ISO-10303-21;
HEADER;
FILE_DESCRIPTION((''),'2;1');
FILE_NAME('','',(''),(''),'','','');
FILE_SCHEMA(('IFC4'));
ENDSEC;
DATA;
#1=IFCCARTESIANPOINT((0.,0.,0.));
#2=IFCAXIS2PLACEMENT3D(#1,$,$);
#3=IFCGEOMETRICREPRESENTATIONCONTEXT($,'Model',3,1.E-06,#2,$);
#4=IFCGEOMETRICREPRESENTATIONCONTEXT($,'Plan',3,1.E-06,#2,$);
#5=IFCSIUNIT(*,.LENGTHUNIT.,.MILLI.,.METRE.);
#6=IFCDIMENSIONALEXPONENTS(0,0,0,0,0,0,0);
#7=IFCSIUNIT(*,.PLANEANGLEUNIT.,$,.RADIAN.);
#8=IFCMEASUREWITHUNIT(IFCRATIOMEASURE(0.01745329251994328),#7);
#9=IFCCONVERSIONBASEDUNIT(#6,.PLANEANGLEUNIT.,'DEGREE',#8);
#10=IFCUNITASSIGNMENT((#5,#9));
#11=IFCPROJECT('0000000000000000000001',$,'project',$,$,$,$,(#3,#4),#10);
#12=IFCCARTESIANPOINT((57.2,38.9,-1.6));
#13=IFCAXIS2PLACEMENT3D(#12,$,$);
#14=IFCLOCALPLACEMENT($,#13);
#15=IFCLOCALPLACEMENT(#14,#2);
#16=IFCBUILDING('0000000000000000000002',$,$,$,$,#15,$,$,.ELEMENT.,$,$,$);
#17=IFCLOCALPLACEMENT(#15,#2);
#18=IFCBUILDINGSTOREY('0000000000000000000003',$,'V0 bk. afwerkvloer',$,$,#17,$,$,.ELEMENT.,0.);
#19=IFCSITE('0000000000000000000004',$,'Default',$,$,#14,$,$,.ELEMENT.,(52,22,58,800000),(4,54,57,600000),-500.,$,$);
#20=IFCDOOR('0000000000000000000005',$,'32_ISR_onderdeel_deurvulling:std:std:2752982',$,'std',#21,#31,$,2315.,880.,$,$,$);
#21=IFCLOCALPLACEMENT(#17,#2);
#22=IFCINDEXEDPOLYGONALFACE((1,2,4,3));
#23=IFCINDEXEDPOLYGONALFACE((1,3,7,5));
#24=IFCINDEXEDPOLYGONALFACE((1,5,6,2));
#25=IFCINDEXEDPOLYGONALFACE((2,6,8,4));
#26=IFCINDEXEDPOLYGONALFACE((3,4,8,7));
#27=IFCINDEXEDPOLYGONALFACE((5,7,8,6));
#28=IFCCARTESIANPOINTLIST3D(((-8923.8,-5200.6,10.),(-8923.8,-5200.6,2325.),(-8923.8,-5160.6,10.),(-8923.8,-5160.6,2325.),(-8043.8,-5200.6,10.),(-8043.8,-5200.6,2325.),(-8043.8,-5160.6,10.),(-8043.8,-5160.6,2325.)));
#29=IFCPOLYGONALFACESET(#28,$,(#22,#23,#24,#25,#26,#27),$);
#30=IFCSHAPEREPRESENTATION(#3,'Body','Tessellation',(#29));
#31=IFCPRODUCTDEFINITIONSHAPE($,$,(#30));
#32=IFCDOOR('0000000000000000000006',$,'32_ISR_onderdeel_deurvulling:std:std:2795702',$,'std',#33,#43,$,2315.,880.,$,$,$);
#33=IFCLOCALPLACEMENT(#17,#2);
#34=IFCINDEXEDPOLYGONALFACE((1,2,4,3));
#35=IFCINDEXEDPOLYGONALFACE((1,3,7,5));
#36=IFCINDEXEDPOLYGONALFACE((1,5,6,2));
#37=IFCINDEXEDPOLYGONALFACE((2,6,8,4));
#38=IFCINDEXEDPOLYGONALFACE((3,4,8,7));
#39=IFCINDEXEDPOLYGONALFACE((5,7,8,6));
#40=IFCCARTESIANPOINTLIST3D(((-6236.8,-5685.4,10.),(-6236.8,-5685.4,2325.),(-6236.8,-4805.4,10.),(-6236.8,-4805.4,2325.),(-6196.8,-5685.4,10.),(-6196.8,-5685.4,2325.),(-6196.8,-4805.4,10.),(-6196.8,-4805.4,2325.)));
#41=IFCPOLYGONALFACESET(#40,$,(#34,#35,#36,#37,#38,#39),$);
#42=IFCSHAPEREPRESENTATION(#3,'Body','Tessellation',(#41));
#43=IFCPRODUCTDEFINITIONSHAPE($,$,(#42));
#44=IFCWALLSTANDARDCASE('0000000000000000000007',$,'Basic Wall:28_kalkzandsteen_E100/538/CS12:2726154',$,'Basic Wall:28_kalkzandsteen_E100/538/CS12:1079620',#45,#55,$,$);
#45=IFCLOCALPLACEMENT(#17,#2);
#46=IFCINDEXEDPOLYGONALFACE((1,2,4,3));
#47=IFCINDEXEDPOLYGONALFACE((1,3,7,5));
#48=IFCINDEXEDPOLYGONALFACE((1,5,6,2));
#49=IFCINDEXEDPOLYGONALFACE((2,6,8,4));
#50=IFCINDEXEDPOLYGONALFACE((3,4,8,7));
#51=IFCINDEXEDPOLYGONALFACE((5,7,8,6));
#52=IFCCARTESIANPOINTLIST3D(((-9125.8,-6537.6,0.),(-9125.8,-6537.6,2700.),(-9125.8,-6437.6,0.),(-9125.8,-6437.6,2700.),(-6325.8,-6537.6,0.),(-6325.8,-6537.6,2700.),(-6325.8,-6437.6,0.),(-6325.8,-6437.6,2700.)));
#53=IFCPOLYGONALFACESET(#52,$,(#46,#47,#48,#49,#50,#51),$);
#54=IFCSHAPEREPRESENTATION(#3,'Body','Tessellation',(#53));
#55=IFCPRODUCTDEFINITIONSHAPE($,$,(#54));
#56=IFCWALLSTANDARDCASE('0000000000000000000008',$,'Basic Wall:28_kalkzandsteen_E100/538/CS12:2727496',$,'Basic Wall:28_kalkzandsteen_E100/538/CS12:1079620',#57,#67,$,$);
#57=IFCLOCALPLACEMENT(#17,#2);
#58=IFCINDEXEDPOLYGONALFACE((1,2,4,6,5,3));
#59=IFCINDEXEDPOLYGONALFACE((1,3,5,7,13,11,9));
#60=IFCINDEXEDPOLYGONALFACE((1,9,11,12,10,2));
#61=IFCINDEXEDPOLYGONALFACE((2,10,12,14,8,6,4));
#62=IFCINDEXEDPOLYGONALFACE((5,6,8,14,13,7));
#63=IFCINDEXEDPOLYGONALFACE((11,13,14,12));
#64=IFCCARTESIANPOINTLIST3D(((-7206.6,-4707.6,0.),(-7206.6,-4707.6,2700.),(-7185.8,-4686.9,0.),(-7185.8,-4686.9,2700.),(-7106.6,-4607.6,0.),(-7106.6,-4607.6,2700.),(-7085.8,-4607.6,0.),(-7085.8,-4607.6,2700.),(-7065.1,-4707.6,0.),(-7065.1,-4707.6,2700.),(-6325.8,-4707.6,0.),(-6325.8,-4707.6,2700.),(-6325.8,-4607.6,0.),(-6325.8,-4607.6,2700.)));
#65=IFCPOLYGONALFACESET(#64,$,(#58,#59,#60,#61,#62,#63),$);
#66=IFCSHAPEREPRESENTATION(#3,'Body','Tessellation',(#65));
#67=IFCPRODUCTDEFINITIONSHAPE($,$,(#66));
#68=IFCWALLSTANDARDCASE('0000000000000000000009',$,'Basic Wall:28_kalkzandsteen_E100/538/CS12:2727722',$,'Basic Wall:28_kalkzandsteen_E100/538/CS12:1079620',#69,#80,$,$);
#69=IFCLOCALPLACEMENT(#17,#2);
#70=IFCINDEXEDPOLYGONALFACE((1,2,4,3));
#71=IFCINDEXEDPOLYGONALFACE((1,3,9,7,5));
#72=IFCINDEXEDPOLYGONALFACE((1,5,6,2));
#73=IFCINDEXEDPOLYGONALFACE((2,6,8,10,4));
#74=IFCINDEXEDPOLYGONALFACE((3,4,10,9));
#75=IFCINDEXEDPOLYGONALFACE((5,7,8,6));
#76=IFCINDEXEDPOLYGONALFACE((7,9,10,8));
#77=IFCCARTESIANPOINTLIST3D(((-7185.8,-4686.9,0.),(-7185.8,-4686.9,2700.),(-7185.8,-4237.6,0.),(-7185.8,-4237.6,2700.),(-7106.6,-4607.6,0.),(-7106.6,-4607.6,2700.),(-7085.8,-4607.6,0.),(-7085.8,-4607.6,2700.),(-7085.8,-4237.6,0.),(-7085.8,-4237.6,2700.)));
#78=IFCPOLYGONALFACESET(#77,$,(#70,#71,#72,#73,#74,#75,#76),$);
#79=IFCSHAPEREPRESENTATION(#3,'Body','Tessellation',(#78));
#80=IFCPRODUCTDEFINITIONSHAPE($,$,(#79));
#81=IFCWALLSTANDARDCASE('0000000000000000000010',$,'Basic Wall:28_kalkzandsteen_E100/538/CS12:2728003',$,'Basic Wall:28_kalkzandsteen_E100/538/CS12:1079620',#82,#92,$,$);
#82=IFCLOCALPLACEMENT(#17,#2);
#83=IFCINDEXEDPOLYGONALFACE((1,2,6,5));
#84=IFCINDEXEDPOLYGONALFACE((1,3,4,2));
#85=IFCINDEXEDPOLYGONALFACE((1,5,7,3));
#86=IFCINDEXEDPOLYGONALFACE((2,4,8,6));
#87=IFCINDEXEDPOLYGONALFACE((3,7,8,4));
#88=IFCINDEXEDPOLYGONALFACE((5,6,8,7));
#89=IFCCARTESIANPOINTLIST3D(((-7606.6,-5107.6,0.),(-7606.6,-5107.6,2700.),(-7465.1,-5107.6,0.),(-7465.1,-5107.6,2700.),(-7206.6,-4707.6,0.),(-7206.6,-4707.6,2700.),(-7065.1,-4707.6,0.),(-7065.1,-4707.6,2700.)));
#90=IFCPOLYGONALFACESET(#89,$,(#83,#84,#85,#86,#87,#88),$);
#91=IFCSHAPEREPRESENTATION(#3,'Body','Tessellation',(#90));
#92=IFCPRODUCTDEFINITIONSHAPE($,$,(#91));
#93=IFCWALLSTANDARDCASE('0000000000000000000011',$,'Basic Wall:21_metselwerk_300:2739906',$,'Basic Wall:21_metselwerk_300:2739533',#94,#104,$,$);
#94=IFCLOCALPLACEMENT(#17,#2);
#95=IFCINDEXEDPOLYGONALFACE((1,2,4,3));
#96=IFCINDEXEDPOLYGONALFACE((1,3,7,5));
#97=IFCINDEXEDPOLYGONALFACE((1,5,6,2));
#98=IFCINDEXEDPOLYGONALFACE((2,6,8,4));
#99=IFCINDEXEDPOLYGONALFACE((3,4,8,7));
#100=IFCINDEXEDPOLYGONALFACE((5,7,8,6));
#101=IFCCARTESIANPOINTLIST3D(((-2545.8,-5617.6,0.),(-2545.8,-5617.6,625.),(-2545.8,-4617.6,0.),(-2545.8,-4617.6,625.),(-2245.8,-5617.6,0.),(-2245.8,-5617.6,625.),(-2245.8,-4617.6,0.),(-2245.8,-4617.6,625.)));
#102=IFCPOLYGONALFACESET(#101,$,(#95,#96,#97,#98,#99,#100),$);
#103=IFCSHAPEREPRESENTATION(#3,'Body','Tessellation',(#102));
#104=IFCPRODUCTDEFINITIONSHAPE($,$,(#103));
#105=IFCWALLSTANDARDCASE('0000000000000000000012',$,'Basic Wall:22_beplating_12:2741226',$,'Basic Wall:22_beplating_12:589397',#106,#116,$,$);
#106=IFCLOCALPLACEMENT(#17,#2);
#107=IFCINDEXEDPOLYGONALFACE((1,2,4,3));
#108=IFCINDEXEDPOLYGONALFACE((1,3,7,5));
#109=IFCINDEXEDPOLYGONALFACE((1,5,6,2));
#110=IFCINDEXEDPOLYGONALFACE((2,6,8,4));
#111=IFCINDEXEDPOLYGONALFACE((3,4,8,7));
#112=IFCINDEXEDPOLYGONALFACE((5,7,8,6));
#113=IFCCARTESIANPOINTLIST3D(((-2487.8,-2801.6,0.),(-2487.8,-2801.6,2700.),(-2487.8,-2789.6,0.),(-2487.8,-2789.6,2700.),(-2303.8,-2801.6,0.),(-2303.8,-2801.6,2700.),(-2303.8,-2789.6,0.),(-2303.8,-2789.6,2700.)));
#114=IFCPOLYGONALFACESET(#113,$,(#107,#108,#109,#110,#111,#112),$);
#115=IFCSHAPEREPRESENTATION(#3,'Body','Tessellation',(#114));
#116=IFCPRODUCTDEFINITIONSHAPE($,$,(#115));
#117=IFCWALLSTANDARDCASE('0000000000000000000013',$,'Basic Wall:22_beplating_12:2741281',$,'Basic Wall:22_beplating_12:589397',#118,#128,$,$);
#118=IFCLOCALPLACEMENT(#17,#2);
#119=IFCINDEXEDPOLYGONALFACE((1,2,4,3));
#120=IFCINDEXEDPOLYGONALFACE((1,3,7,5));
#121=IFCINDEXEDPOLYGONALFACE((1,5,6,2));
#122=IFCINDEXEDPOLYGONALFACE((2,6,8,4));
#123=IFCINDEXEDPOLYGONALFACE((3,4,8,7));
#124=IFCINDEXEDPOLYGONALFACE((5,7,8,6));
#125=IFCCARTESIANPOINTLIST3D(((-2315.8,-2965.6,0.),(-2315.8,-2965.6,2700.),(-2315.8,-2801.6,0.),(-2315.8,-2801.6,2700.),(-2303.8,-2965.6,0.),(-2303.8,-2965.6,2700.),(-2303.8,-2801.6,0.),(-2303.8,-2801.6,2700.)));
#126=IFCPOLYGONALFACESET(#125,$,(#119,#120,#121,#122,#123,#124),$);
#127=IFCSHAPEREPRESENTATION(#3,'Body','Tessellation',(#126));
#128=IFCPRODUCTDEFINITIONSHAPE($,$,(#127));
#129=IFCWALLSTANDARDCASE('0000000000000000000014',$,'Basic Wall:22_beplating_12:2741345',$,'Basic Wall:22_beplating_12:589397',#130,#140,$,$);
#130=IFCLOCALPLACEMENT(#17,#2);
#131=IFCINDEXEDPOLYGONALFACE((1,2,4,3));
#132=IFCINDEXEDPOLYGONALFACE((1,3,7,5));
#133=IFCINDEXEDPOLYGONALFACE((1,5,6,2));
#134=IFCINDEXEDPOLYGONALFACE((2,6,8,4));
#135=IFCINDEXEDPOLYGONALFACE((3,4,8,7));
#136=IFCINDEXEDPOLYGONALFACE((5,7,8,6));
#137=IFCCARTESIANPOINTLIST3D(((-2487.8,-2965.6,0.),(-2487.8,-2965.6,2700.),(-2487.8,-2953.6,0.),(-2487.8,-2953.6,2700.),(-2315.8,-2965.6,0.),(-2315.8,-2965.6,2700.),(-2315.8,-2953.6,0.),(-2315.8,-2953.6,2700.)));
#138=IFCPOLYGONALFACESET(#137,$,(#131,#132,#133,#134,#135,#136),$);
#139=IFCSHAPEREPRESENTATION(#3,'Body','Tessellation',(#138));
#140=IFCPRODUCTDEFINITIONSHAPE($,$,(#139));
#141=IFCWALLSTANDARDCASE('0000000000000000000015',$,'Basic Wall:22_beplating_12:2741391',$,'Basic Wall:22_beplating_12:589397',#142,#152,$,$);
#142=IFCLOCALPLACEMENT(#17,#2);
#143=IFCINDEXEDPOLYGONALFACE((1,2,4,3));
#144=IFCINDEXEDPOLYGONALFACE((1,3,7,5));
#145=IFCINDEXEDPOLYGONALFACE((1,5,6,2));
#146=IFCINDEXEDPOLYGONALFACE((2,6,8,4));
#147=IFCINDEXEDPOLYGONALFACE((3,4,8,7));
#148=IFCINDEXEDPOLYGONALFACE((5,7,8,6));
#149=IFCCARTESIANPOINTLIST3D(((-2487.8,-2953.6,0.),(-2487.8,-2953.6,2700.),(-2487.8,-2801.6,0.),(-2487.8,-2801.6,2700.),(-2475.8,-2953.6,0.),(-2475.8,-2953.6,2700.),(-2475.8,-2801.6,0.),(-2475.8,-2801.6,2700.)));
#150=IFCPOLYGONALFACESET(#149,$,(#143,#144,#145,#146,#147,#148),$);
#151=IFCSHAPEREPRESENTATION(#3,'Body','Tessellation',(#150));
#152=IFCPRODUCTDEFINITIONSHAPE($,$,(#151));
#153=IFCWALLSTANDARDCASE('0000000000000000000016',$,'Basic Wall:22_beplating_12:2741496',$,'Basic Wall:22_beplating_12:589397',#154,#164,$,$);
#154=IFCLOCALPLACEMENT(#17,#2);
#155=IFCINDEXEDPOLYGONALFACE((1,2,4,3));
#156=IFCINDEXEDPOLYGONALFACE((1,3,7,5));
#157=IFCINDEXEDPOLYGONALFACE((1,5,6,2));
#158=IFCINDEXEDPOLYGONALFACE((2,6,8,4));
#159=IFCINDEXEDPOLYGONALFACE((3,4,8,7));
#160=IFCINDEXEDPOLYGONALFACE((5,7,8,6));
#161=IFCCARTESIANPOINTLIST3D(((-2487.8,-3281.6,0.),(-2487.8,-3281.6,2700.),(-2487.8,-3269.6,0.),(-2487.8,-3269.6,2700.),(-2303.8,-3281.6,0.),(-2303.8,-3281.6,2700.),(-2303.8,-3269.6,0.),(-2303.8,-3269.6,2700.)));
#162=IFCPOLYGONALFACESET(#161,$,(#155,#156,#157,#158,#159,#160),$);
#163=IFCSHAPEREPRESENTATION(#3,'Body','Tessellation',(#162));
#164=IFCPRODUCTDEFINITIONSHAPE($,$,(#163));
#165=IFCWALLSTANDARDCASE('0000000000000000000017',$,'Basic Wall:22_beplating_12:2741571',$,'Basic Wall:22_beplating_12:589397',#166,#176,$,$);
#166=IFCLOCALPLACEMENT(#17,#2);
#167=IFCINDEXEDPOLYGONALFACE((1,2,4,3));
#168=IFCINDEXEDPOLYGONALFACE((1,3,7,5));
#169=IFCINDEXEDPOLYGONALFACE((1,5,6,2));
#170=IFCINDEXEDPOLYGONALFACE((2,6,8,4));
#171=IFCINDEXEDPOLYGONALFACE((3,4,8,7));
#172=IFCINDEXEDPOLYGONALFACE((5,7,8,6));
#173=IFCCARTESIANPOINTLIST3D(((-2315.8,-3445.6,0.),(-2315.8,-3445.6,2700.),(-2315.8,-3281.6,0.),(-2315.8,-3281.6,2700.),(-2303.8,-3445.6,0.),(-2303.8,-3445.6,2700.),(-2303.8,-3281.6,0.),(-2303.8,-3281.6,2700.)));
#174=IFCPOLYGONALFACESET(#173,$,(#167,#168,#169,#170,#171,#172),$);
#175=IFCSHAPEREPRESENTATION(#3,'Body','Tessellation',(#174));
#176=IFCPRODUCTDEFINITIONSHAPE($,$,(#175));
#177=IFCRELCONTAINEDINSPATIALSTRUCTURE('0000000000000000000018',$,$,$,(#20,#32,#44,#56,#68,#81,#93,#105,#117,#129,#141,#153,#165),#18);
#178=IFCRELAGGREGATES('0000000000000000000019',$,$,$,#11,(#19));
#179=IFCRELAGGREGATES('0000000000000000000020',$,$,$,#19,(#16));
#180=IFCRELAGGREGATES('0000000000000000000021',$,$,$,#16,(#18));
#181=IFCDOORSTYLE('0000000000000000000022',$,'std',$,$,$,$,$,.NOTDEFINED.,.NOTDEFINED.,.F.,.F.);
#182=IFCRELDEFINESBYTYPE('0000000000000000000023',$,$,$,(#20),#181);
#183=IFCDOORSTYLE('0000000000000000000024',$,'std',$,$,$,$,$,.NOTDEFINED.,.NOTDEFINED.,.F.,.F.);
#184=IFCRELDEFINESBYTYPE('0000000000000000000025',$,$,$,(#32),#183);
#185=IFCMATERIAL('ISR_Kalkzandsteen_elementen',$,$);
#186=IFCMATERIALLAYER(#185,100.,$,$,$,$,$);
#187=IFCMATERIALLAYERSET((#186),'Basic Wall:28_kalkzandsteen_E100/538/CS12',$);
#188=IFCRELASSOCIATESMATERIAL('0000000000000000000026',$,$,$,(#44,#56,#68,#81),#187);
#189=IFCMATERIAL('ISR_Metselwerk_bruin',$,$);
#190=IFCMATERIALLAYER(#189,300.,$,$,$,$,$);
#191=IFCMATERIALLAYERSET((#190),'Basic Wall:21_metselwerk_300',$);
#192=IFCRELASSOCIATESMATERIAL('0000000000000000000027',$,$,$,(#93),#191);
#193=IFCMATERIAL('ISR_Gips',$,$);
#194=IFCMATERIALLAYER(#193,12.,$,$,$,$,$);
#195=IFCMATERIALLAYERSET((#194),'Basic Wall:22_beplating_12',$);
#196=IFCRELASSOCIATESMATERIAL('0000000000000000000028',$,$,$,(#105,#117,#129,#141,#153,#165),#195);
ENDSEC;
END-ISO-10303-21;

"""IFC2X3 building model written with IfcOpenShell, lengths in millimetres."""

from ifc_helpers import new_model, entity, si_unit, converted_unit, frame, frame_2d, origin, origin_2d_with_axis, place, context, project, spatial, polyline, rectangle, outline, extrude, source, transform, mapped, material, layer, layer_set, layer_usage, type_object, type_shapes, element, save


model = new_model("IFC2X3")

# Units and contexts
model_context = context("Model", 3, precision=1e-06, world=origin())
plan_context = context("Plan", 3, precision=1e-06, world=origin())
ifc_project = project(units=[si_unit("LENGTHUNIT", "METRE", prefix="MILLI"), converted_unit("PLANEANGLEUNIT", "DEGREE", entity("IfcRatioMeasure", 0.01745329251994328), si_unit("PLANEANGLEUNIT", "RADIAN"), dimensions=[0, 0, 0, 0, 0, 0, 0])], contexts=[model_context, plan_context])

# Site, building, storey
site_placement = place(None, frame((57.2, 38.9, -1.6)))
site = spatial("IfcSite", under=ifc_project, at=site_placement, Name="Default", CompositionType="ELEMENT", RefLatitude=(52, 22, 58, 800000), RefLongitude=(4, 54, 57, 600000), RefElevation=-500.0)
building_placement = place(site_placement, origin())
building = spatial("IfcBuilding", under=site, at=building_placement, CompositionType="ELEMENT")
storey_placement = place(building_placement, origin())
storey = spatial("IfcBuildingStorey", under=building, at=storey_placement, Name="V0 bk. afwerkvloer", CompositionType="ELEMENT", Elevation=0.0)

# Doors
door_style_1 = type_object("IfcDoorStyle", Name="std", ConstructionType="NOTDEFINED", OperationType="NOTDEFINED", ParameterTakesPrecedence=False, Sizeable=False)
shared_shape_1 = source(origin(), model_context, "Body", "SweptSolid", [
    extrude(rectangle(XDim=880.0, YDim=40.0, at=origin_2d_with_axis()), frame((0.0, 34.0, 0.0)), (0.0, 0.0, 1.0), 2315.0),
])
type_shapes(door_style_1, [shared_shape_1])
door_1_placement = place(storey_placement, frame((-8483.8, -5214.6, 10.0)))
element("IfcDoor", 1, at=door_1_placement, inside=storey, type_object=door_style_1, Name="32_ISR_onderdeel_deurvulling:std:std:2752982", ObjectType="std", OverallHeight=2315.0, OverallWidth=880.0, context=model_context, shape_type="MappedRepresentation", body=[
    mapped(shared_shape_1, transform((0.0, 0.0, 0.0), scale=1.0)),
])
door_style_2 = type_object("IfcDoorStyle", Name="std", ConstructionType="NOTDEFINED", OperationType="NOTDEFINED", ParameterTakesPrecedence=False, Sizeable=False)
shared_shape_2 = source(origin(), model_context, "Body", "SweptSolid", [
    extrude(rectangle(XDim=40.0, YDim=880.0, at=origin_2d_with_axis()), frame((0.0, -34.0, 0.0), z_axis=(0.0, 0.0, 1.0), x_axis=(0.0, -1.0, 0.0)), (0.0, 0.0, 1.0), 2315.0),
])
type_shapes(door_style_2, [shared_shape_2])
door_2_placement = place(storey_placement, frame((-6250.8, -5245.4, 10.0), z_axis=(0.0, 0.0, 1.0), x_axis=(0.0, 1.0, 0.0)))
element("IfcDoor", 2, at=door_2_placement, inside=storey, type_object=door_style_2, Name="32_ISR_onderdeel_deurvulling:std:std:2795702", ObjectType="std", OverallHeight=2315.0, OverallWidth=880.0, context=model_context, shape_type="MappedRepresentation", body=[
    mapped(shared_shape_2, transform((0.0, 0.0, 0.0), scale=1.0)),
])

# Shared definitions
ifc_material_1 = material(Name="ISR_Kalkzandsteen_elementen")
ifc_layer_1 = layer(ifc_material_1, 100.0)
ifc_layer_set_1 = layer_set([ifc_layer_1], Name="Basic Wall:28_kalkzandsteen_E100/538/CS12")

# Walls
ifc_layer_usage_1 = layer_usage(ifc_layer_set_1, "AXIS2", "NEGATIVE", 50.0)
wall_1_placement = place(storey_placement, frame((-6325.8, -6487.6, 0.0), z_axis=(0.0, 0.0, 1.0), x_axis=(-1.0, 0.0, 0.0)))
element("IfcWallStandardCase", 3, at=wall_1_placement, inside=storey, material=ifc_layer_usage_1, Name="Basic Wall:28_kalkzandsteen_E100/538/CS12:2726154", ObjectType="Basic Wall:28_kalkzandsteen_E100/538/CS12:1079620", context=model_context, shape_type="SweptSolid", body=[
    extrude(rectangle(XDim=2800.0, YDim=100.0, at=frame_2d((1400.0, 0.0), x_axis=(-1.0, 0.0))), origin(), (0.0, 0.0, 1.0), 2700.0),
])
ifc_layer_usage_2 = layer_usage(ifc_layer_set_1, "AXIS2", "POSITIVE", -50.0)
wall_2_placement = place(storey_placement, frame((-6325.8, -4657.6, 0.0), z_axis=(0.0, 0.0, 1.0), x_axis=(-1.0, 0.0, 0.0)))
element("IfcWallStandardCase", 4, at=wall_2_placement, inside=storey, material=ifc_layer_usage_2, Name="Basic Wall:28_kalkzandsteen_E100/538/CS12:2727496", ObjectType="Basic Wall:28_kalkzandsteen_E100/538/CS12:1079620", context=model_context, shape_type="SweptSolid", body=[
    extrude(outline(polyline([(780.7, -50.0), (860.0, 29.3), (880.7, 50.0), (739.3, 50.0), (0.0, 50.0), (0.0, -50.0), (760.0, -50.0), (780.7, -50.0)])), origin(), (0.0, 0.0, 1.0), 2700.0),
])
ifc_layer_usage_3 = layer_usage(ifc_layer_set_1, "AXIS2", "NEGATIVE", 50.0)
wall_3_placement = place(storey_placement, frame((-7135.8, -4237.6, 0.0), z_axis=(0.0, 0.0, 1.0), x_axis=(0.0, -1.0, 0.0)))
element("IfcWallStandardCase", 5, at=wall_3_placement, inside=storey, material=ifc_layer_usage_3, Name="Basic Wall:28_kalkzandsteen_E100/538/CS12:2727722", ObjectType="Basic Wall:28_kalkzandsteen_E100/538/CS12:1079620", context=model_context, shape_type="SweptSolid", body=[
    extrude(outline(polyline([(449.3, -50.0), (370.0, 29.3), (370.0, 50.0), (0.0, 50.0), (0.0, -50.0), (449.3, -50.0)])), origin(), (0.0, 0.0, 1.0), 2700.0),
])
ifc_layer_usage_4 = layer_usage(ifc_layer_set_1, "AXIS2", "POSITIVE", -50.0)
wall_4_placement = place(storey_placement, frame((-7571.2, -5143.0, 0.0), z_axis=(0.0, 0.0, 1.0), x_axis=(0.707107, 0.707107, 0.0)))
element("IfcWallStandardCase", 6, at=wall_4_placement, inside=storey, material=ifc_layer_usage_4, Name="Basic Wall:28_kalkzandsteen_E100/538/CS12:2728003", ObjectType="Basic Wall:28_kalkzandsteen_E100/538/CS12:1079620", context=model_context, shape_type="SweptSolid", body=[
    extrude(outline(polyline([(665.7, -50.0), (565.7, 50.0), (0.0, 50.0), (100.0, -50.0), (665.7, -50.0)])), origin(), (0.0, 0.0, 1.0), 2700.0),
])
ifc_material_2 = material(Name="ISR_Metselwerk_bruin")
ifc_layer_2 = layer(ifc_material_2, 300.0)
ifc_layer_set_2 = layer_set([ifc_layer_2], Name="Basic Wall:21_metselwerk_300")
ifc_layer_usage_5 = layer_usage(ifc_layer_set_2, "AXIS2", "POSITIVE", -150.0)
wall_5_placement = place(storey_placement, frame((-2395.8, -4617.6, 0.0), z_axis=(0.0, 0.0, 1.0), x_axis=(0.0, -1.0, 0.0)))
element("IfcWallStandardCase", 7, at=wall_5_placement, inside=storey, material=ifc_layer_usage_5, Name="Basic Wall:21_metselwerk_300:2739906", ObjectType="Basic Wall:21_metselwerk_300:2739533", context=model_context, shape_type="SweptSolid", body=[
    extrude(rectangle(XDim=1000.0, YDim=300.0, at=frame_2d((500.0, 0.0), x_axis=(-1.0, 0.0))), origin(), (0.0, 0.0, 1.0), 625.0),
])
ifc_material_3 = material(Name="ISR_Gips")
ifc_layer_3 = layer(ifc_material_3, 12.0)
ifc_layer_set_3 = layer_set([ifc_layer_3], Name="Basic Wall:22_beplating_12")
ifc_layer_usage_6 = layer_usage(ifc_layer_set_3, "AXIS2", "POSITIVE", -6.0)
wall_6_placement = place(storey_placement, frame((-2487.8, -2795.6, 0.0)))
element("IfcWallStandardCase", 8, at=wall_6_placement, inside=storey, material=ifc_layer_usage_6, Name="Basic Wall:22_beplating_12:2741226", ObjectType="Basic Wall:22_beplating_12:589397", context=model_context, shape_type="SweptSolid", body=[
    extrude(rectangle(XDim=184.0, YDim=12.0, at=frame_2d((92.0, 0.0), x_axis=(-1.0, 0.0))), origin(), (0.0, 0.0, 1.0), 2700.0),
])
ifc_layer_usage_7 = layer_usage(ifc_layer_set_3, "AXIS2", "POSITIVE", -6.0)
wall_7_placement = place(storey_placement, frame((-2309.8, -2801.6, 0.0), z_axis=(0.0, 0.0, 1.0), x_axis=(0.0, -1.0, 0.0)))
element("IfcWallStandardCase", 9, at=wall_7_placement, inside=storey, material=ifc_layer_usage_7, Name="Basic Wall:22_beplating_12:2741281", ObjectType="Basic Wall:22_beplating_12:589397", context=model_context, shape_type="SweptSolid", body=[
    extrude(rectangle(XDim=164.0, YDim=12.0, at=frame_2d((82.0, 0.0), x_axis=(-1.0, 0.0))), origin(), (0.0, 0.0, 1.0), 2700.0),
])
ifc_layer_usage_8 = layer_usage(ifc_layer_set_3, "AXIS2", "POSITIVE", -6.0)
wall_8_placement = place(storey_placement, frame((-2315.8, -2959.6, 0.0), z_axis=(0.0, 0.0, 1.0), x_axis=(-1.0, 0.0, 0.0)))
element("IfcWallStandardCase", 10, at=wall_8_placement, inside=storey, material=ifc_layer_usage_8, Name="Basic Wall:22_beplating_12:2741345", ObjectType="Basic Wall:22_beplating_12:589397", context=model_context, shape_type="SweptSolid", body=[
    extrude(rectangle(XDim=172.0, YDim=12.0, at=frame_2d((86.0, 0.0), x_axis=(-1.0, 0.0))), origin(), (0.0, 0.0, 1.0), 2700.0),
])
ifc_layer_usage_9 = layer_usage(ifc_layer_set_3, "AXIS2", "POSITIVE", -6.0)
wall_9_placement = place(storey_placement, frame((-2481.8, -2953.6, 0.0), z_axis=(0.0, 0.0, 1.0), x_axis=(0.0, 1.0, 0.0)))
element("IfcWallStandardCase", 11, at=wall_9_placement, inside=storey, material=ifc_layer_usage_9, Name="Basic Wall:22_beplating_12:2741391", ObjectType="Basic Wall:22_beplating_12:589397", context=model_context, shape_type="SweptSolid", body=[
    extrude(rectangle(XDim=152.0, YDim=12.0, at=frame_2d((76.0, 0.0), x_axis=(-1.0, 0.0))), origin(), (0.0, 0.0, 1.0), 2700.0),
])
ifc_layer_usage_10 = layer_usage(ifc_layer_set_3, "AXIS2", "POSITIVE", -6.0)
wall_10_placement = place(storey_placement, frame((-2487.8, -3275.6, 0.0)))
element("IfcWallStandardCase", 12, at=wall_10_placement, inside=storey, material=ifc_layer_usage_10, Name="Basic Wall:22_beplating_12:2741496", ObjectType="Basic Wall:22_beplating_12:589397", context=model_context, shape_type="SweptSolid", body=[
    extrude(rectangle(XDim=184.0, YDim=12.0, at=frame_2d((92.0, 0.0), x_axis=(-1.0, 0.0))), origin(), (0.0, 0.0, 1.0), 2700.0),
])
ifc_layer_usage_11 = layer_usage(ifc_layer_set_3, "AXIS2", "POSITIVE", -6.0)
wall_11_placement = place(storey_placement, frame((-2309.8, -3281.6, 0.0), z_axis=(0.0, 0.0, 1.0), x_axis=(0.0, -1.0, 0.0)))
element("IfcWallStandardCase", 13, at=wall_11_placement, inside=storey, material=ifc_layer_usage_11, Name="Basic Wall:22_beplating_12:2741571", ObjectType="Basic Wall:22_beplating_12:589397", context=model_context, shape_type="SweptSolid", body=[
    extrude(rectangle(XDim=164.0, YDim=12.0, at=frame_2d((82.0, 0.0), x_axis=(-1.0, 0.0))), origin(), (0.0, 0.0, 1.0), 2700.0),
])

save(model, "model.ifc")
